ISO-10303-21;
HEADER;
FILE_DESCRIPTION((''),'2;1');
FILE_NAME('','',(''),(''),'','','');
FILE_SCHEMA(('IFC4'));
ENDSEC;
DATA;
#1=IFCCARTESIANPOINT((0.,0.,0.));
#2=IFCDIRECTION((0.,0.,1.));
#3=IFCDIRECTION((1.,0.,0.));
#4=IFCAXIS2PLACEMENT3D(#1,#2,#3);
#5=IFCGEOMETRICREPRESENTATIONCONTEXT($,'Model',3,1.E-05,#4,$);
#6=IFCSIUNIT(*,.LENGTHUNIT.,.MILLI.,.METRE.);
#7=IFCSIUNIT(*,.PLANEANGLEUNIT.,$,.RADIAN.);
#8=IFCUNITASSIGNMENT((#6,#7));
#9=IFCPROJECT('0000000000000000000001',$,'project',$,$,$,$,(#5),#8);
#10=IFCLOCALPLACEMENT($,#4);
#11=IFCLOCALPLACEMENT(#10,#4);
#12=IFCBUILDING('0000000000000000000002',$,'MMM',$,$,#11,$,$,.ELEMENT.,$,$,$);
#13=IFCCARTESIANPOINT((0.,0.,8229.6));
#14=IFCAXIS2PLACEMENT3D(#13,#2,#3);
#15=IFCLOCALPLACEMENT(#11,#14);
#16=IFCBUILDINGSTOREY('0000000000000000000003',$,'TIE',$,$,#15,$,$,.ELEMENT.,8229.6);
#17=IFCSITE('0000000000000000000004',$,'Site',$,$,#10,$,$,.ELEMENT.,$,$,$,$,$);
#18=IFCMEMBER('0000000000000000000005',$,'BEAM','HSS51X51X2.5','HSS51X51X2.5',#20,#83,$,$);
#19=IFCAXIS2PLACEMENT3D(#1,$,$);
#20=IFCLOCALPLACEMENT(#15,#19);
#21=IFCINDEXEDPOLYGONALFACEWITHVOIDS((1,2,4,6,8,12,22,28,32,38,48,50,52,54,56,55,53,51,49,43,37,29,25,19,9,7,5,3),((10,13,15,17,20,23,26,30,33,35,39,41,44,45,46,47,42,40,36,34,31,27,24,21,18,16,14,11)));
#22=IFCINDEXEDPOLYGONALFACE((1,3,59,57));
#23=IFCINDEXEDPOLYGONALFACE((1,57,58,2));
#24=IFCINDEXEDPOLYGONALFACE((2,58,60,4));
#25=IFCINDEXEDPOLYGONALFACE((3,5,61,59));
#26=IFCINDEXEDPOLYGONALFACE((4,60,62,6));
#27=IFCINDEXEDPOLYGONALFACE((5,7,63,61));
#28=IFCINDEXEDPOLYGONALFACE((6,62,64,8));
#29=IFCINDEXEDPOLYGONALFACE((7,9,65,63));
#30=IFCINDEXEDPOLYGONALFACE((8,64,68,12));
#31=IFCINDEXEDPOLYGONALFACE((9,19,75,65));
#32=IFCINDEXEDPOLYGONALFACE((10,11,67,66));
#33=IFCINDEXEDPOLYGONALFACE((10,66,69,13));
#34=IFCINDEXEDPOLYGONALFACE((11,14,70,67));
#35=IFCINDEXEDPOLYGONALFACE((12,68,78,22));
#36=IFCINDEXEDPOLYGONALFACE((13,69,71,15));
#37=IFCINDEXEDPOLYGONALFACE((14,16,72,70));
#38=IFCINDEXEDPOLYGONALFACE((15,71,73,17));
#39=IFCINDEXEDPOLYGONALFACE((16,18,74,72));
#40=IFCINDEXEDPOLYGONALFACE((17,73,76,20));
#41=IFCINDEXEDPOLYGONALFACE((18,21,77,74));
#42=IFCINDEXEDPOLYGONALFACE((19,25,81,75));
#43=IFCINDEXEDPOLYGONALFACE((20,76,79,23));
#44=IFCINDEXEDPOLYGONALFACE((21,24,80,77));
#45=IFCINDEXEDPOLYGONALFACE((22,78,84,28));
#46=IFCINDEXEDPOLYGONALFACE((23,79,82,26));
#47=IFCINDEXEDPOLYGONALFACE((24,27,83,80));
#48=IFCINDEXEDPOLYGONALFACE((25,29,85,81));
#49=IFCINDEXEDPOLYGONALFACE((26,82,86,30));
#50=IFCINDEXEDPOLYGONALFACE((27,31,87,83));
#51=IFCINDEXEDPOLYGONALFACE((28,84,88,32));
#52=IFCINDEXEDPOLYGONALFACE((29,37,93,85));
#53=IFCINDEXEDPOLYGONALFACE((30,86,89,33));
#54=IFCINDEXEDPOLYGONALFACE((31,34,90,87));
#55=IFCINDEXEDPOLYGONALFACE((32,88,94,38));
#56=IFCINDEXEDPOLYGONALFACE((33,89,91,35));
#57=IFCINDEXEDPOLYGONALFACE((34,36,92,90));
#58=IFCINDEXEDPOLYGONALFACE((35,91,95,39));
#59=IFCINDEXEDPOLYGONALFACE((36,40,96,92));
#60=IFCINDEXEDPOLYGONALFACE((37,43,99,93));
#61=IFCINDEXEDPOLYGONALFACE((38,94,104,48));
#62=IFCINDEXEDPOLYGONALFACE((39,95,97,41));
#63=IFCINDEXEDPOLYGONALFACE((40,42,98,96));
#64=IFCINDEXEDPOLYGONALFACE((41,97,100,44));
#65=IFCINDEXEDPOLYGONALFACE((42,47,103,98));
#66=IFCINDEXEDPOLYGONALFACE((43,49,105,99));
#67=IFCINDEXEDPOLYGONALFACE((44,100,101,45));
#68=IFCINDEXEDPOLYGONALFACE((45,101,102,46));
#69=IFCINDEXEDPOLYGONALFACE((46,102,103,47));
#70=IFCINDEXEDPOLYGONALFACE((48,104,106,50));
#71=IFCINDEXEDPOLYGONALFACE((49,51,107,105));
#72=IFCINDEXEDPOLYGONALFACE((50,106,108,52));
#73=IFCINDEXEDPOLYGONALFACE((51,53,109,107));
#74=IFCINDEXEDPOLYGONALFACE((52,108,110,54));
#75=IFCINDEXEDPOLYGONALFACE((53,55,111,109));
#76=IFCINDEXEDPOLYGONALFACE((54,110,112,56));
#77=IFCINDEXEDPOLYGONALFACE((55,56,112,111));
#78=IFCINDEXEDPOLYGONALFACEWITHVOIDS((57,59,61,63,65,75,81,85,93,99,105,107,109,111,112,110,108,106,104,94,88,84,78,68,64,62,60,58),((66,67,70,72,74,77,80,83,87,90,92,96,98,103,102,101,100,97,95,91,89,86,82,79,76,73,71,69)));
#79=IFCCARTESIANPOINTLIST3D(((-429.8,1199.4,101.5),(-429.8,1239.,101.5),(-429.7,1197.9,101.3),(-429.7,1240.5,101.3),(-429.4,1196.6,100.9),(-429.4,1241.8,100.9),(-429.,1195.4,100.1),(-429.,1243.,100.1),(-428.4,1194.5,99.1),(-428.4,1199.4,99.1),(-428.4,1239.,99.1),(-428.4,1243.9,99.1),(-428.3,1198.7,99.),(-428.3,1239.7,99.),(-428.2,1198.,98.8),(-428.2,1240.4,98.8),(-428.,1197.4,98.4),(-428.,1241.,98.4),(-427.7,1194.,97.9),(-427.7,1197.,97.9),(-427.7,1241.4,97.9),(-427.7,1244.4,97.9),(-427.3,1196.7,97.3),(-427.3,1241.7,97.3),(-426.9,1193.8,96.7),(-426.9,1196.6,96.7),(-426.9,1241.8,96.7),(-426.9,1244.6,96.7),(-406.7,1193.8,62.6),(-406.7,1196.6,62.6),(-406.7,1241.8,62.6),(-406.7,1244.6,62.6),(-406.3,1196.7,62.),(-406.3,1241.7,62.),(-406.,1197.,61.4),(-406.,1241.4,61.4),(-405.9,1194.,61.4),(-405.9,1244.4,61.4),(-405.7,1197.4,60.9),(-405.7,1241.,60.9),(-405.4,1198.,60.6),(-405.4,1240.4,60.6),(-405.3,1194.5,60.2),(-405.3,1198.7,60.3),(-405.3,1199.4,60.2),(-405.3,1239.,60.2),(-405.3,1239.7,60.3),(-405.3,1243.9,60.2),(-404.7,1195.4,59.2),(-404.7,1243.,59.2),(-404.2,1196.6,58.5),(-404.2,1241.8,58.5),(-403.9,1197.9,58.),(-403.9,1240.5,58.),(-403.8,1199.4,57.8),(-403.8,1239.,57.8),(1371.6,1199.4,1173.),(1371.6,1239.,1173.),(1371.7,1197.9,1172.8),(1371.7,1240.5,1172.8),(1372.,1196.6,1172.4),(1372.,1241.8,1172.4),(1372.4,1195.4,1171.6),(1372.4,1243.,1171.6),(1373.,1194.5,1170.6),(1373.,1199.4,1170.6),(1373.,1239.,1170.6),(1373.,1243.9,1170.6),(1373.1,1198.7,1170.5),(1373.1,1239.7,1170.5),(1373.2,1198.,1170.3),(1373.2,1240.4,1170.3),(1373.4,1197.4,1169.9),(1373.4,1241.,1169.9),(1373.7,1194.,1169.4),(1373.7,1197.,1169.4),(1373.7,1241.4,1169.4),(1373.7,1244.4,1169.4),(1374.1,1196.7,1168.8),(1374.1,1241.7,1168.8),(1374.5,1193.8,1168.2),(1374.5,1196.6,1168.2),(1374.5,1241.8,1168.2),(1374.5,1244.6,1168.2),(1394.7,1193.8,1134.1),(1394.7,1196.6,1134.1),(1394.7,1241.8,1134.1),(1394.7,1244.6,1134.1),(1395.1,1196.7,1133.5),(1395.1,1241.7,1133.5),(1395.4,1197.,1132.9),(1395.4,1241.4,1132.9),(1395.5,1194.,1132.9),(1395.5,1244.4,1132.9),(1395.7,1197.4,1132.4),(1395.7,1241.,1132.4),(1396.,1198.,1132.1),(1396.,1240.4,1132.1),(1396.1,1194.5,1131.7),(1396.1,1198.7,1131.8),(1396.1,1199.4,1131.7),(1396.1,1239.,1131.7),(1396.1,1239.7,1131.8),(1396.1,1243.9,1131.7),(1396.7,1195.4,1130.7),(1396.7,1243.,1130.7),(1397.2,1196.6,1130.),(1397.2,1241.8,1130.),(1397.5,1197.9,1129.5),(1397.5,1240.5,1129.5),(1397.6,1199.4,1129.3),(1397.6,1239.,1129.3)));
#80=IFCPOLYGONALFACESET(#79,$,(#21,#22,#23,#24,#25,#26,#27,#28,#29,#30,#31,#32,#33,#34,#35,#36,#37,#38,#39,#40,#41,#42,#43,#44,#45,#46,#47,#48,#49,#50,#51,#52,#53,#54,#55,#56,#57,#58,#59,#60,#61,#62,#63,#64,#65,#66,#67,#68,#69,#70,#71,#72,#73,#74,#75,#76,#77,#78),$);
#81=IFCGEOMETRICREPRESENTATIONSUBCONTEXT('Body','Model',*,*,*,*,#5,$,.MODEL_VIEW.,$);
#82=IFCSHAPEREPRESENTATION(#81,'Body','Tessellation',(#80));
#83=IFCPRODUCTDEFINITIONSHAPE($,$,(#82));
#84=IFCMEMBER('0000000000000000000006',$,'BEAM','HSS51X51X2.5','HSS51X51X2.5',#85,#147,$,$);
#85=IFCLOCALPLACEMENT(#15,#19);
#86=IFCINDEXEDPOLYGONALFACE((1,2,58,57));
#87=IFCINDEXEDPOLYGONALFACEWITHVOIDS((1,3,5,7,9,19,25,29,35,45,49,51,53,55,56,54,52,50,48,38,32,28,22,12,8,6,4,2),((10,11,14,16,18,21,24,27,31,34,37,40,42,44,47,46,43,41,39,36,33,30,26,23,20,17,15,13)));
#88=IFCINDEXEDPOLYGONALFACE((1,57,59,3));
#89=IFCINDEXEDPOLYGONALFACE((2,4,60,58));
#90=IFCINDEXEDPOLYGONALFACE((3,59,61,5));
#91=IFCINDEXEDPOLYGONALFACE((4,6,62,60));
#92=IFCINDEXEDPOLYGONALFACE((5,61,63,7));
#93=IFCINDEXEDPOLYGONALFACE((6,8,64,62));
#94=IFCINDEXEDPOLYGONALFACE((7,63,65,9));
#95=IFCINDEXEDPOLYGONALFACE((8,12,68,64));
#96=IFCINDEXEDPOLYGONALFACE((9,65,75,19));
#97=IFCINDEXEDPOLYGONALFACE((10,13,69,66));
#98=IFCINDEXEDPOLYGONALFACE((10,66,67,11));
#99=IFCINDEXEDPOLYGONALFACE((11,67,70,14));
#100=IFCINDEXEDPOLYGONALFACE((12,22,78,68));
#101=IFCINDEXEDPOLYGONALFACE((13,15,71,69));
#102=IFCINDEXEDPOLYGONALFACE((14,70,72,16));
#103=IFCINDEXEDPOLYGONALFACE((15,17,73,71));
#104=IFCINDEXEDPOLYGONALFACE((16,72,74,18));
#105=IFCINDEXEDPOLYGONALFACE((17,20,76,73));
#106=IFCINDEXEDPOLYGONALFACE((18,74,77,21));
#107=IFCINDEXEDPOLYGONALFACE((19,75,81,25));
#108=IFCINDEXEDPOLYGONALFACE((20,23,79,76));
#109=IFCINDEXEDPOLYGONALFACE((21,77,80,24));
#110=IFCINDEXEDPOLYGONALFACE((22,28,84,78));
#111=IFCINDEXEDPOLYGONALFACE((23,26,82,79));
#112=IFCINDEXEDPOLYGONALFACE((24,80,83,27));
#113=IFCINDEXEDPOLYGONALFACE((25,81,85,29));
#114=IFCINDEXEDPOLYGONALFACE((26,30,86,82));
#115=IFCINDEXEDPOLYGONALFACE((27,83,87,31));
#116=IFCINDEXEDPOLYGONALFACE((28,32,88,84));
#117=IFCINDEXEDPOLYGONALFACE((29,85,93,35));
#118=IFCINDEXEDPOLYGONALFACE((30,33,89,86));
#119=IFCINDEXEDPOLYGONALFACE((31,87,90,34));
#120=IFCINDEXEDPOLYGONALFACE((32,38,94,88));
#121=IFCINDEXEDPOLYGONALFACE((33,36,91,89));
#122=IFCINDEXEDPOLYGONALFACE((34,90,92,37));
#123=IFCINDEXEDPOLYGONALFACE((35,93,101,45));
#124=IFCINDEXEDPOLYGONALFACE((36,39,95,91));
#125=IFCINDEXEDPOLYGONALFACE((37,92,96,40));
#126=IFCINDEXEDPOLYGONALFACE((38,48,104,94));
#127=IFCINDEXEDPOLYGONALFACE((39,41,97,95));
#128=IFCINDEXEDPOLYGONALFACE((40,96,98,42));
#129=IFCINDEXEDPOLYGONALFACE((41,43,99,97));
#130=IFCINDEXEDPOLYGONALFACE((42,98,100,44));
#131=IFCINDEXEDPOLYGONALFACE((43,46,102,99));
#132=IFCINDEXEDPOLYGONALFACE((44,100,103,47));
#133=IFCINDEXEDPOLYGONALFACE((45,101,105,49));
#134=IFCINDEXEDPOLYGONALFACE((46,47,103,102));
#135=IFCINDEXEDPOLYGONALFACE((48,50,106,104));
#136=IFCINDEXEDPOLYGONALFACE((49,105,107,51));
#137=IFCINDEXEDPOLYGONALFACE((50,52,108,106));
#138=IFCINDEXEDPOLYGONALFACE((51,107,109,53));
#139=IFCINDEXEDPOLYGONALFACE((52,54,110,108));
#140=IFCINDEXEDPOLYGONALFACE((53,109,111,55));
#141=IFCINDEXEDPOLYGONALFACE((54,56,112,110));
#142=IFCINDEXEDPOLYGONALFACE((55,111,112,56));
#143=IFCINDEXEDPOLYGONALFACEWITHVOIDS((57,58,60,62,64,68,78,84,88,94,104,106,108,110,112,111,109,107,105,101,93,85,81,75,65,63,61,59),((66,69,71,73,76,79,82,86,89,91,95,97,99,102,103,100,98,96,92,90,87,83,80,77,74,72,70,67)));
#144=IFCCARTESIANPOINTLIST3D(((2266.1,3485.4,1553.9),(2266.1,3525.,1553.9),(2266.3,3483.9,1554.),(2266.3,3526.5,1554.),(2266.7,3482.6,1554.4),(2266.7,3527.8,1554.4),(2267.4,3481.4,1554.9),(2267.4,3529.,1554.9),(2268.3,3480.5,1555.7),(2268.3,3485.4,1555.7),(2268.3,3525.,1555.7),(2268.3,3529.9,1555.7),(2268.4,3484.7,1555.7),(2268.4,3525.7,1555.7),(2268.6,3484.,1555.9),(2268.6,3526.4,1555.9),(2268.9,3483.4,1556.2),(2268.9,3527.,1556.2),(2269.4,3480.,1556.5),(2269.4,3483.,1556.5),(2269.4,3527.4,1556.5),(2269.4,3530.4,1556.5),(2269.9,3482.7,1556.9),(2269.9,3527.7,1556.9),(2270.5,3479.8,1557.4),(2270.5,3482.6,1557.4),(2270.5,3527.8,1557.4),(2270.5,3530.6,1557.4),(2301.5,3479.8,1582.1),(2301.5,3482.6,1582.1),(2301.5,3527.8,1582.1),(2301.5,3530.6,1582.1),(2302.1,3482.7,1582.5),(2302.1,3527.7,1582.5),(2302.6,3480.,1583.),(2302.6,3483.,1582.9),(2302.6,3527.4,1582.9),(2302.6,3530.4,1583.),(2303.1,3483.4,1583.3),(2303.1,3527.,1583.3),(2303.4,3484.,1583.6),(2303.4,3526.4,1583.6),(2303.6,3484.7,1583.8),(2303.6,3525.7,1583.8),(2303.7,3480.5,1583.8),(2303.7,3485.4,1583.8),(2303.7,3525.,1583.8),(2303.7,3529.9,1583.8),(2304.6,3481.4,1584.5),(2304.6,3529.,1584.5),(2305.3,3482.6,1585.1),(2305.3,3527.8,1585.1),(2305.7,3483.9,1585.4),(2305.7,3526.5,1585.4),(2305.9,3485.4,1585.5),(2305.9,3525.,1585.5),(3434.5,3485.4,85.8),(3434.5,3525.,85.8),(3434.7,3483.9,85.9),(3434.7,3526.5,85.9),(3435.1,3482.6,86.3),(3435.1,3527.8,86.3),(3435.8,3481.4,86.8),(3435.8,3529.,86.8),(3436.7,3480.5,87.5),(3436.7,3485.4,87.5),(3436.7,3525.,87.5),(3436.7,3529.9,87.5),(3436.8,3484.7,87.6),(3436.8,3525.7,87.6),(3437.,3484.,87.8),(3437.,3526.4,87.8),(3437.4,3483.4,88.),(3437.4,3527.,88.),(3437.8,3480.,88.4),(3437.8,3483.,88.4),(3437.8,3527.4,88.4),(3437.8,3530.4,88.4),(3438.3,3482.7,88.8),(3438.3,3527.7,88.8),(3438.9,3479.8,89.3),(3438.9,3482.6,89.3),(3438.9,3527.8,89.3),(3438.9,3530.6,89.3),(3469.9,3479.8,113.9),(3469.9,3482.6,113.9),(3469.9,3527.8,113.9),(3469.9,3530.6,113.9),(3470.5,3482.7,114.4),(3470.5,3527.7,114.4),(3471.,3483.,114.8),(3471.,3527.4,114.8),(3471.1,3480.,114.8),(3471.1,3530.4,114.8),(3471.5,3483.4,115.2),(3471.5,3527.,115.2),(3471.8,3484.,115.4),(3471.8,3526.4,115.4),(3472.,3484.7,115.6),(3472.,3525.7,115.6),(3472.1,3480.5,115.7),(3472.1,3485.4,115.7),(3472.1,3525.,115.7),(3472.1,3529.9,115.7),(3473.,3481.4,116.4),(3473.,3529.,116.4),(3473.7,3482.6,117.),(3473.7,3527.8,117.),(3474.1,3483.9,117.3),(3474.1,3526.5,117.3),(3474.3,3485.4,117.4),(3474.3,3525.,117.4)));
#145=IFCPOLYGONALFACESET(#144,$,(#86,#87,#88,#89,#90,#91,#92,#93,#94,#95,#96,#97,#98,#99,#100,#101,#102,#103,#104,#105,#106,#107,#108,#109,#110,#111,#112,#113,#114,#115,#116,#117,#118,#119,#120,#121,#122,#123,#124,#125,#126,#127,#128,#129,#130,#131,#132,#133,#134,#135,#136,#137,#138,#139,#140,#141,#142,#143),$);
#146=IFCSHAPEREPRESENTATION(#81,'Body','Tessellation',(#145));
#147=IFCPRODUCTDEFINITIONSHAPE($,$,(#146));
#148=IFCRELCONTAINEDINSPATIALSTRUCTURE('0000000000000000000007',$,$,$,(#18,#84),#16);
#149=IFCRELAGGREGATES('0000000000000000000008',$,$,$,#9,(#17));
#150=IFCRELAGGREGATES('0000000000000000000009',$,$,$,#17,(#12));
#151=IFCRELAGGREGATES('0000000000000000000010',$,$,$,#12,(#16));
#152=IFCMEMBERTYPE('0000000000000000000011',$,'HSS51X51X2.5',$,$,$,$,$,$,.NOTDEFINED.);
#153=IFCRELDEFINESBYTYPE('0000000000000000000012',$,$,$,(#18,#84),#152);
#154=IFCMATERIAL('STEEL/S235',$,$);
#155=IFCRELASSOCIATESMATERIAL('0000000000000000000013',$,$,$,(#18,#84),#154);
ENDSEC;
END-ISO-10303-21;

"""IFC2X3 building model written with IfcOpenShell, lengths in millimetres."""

from ifc_helpers import new_model, si_unit, frame, origin_with_axes, origin_2d_with_axis, place, context, subcontext, project, spatial, hollow_rectangle, extrude, material, type_object, element, save


model = new_model("IFC2X3")

# Units and contexts
model_context = context("Model", 3, precision=1e-05, world=origin_with_axes())
body_context = subcontext(model_context, "Body", "Model", "MODEL_VIEW")
ifc_project = project(units=[si_unit("LENGTHUNIT", "METRE", prefix="MILLI"), si_unit("PLANEANGLEUNIT", "RADIAN")], contexts=[model_context])

# Site, building, storey
site_placement = place(None, origin_with_axes())
site = spatial("IfcSite", under=ifc_project, at=site_placement, Name="Site", CompositionType="ELEMENT")
building_placement = place(site_placement, origin_with_axes())
building = spatial("IfcBuilding", under=site, at=building_placement, Name="MMM", CompositionType="ELEMENT")
storey_placement = place(building_placement, frame((0.0, 0.0, 8229.6), z_axis=(0.0, 0.0, 1.0), x_axis=(1.0, 0.0, 0.0)))
storey = spatial("IfcBuildingStorey", under=building, at=storey_placement, Name="TIE", CompositionType="ELEMENT", Elevation=8229.6)

# Shared definitions
ifc_material = material(Name="STEEL/S235")

# Members
member_type_1 = type_object("IfcMemberType", Name="HSS51X51X2.5", PredefinedType="NOTDEFINED")
member_1_placement = place(storey_placement, frame((1384.6, 1219.2, 1151.2), z_axis=(-0.511216, 0.0, 0.859452), x_axis=(-0.859452, 0.0, -0.511216)))
element("IfcMember", 1, at=member_1_placement, inside=storey, type_object=member_type_1, material=ifc_material, Name="BEAM", Description="HSS51X51X2.5", ObjectType="HSS51X51X2.5", context=body_context, shape_type="SweptSolid", body=[
    extrude(hollow_rectangle(XDim=50.8, YDim=50.8, WallThickness=2.8, InnerFilletRadius=2.8, OuterFilletRadius=5.6, at=origin_2d_with_axis()), frame((2096.0, 0.0, 0.0), z_axis=(-1.0, 0.0, 0.0), x_axis=(0.0, -1.0, 0.0)), (0.0, 0.0, 1.0), 2096.0),
])
for number, where, z_axis, x_axis, name in (
    (2, (3454.4, 3505.2, 101.6), (0.782448, 0.0, 0.622716), (-0.622716, 0.0, 0.782448), "BEAM"),
):
    element("IfcMember", number, at=place(storey_placement, frame(where, z_axis=z_axis, x_axis=x_axis)), inside=storey, type_object=member_type_1, material=ifc_material, Name=name, Description="HSS51X51X2.5", ObjectType="HSS51X51X2.5", context=body_context, shape_type="SweptSolid", body=[
        extrude(hollow_rectangle(XDim=50.8, YDim=50.8, WallThickness=2.8, InnerFilletRadius=2.8, OuterFilletRadius=5.6, at=origin_2d_with_axis()), frame((1876.3, 0.0, 0.0), z_axis=(-1.0, 0.0, 0.0), x_axis=(0.0, -1.0, 0.0)), (0.0, 0.0, 1.0), 1876.3),
    ])

save(model, "model.ifc")
